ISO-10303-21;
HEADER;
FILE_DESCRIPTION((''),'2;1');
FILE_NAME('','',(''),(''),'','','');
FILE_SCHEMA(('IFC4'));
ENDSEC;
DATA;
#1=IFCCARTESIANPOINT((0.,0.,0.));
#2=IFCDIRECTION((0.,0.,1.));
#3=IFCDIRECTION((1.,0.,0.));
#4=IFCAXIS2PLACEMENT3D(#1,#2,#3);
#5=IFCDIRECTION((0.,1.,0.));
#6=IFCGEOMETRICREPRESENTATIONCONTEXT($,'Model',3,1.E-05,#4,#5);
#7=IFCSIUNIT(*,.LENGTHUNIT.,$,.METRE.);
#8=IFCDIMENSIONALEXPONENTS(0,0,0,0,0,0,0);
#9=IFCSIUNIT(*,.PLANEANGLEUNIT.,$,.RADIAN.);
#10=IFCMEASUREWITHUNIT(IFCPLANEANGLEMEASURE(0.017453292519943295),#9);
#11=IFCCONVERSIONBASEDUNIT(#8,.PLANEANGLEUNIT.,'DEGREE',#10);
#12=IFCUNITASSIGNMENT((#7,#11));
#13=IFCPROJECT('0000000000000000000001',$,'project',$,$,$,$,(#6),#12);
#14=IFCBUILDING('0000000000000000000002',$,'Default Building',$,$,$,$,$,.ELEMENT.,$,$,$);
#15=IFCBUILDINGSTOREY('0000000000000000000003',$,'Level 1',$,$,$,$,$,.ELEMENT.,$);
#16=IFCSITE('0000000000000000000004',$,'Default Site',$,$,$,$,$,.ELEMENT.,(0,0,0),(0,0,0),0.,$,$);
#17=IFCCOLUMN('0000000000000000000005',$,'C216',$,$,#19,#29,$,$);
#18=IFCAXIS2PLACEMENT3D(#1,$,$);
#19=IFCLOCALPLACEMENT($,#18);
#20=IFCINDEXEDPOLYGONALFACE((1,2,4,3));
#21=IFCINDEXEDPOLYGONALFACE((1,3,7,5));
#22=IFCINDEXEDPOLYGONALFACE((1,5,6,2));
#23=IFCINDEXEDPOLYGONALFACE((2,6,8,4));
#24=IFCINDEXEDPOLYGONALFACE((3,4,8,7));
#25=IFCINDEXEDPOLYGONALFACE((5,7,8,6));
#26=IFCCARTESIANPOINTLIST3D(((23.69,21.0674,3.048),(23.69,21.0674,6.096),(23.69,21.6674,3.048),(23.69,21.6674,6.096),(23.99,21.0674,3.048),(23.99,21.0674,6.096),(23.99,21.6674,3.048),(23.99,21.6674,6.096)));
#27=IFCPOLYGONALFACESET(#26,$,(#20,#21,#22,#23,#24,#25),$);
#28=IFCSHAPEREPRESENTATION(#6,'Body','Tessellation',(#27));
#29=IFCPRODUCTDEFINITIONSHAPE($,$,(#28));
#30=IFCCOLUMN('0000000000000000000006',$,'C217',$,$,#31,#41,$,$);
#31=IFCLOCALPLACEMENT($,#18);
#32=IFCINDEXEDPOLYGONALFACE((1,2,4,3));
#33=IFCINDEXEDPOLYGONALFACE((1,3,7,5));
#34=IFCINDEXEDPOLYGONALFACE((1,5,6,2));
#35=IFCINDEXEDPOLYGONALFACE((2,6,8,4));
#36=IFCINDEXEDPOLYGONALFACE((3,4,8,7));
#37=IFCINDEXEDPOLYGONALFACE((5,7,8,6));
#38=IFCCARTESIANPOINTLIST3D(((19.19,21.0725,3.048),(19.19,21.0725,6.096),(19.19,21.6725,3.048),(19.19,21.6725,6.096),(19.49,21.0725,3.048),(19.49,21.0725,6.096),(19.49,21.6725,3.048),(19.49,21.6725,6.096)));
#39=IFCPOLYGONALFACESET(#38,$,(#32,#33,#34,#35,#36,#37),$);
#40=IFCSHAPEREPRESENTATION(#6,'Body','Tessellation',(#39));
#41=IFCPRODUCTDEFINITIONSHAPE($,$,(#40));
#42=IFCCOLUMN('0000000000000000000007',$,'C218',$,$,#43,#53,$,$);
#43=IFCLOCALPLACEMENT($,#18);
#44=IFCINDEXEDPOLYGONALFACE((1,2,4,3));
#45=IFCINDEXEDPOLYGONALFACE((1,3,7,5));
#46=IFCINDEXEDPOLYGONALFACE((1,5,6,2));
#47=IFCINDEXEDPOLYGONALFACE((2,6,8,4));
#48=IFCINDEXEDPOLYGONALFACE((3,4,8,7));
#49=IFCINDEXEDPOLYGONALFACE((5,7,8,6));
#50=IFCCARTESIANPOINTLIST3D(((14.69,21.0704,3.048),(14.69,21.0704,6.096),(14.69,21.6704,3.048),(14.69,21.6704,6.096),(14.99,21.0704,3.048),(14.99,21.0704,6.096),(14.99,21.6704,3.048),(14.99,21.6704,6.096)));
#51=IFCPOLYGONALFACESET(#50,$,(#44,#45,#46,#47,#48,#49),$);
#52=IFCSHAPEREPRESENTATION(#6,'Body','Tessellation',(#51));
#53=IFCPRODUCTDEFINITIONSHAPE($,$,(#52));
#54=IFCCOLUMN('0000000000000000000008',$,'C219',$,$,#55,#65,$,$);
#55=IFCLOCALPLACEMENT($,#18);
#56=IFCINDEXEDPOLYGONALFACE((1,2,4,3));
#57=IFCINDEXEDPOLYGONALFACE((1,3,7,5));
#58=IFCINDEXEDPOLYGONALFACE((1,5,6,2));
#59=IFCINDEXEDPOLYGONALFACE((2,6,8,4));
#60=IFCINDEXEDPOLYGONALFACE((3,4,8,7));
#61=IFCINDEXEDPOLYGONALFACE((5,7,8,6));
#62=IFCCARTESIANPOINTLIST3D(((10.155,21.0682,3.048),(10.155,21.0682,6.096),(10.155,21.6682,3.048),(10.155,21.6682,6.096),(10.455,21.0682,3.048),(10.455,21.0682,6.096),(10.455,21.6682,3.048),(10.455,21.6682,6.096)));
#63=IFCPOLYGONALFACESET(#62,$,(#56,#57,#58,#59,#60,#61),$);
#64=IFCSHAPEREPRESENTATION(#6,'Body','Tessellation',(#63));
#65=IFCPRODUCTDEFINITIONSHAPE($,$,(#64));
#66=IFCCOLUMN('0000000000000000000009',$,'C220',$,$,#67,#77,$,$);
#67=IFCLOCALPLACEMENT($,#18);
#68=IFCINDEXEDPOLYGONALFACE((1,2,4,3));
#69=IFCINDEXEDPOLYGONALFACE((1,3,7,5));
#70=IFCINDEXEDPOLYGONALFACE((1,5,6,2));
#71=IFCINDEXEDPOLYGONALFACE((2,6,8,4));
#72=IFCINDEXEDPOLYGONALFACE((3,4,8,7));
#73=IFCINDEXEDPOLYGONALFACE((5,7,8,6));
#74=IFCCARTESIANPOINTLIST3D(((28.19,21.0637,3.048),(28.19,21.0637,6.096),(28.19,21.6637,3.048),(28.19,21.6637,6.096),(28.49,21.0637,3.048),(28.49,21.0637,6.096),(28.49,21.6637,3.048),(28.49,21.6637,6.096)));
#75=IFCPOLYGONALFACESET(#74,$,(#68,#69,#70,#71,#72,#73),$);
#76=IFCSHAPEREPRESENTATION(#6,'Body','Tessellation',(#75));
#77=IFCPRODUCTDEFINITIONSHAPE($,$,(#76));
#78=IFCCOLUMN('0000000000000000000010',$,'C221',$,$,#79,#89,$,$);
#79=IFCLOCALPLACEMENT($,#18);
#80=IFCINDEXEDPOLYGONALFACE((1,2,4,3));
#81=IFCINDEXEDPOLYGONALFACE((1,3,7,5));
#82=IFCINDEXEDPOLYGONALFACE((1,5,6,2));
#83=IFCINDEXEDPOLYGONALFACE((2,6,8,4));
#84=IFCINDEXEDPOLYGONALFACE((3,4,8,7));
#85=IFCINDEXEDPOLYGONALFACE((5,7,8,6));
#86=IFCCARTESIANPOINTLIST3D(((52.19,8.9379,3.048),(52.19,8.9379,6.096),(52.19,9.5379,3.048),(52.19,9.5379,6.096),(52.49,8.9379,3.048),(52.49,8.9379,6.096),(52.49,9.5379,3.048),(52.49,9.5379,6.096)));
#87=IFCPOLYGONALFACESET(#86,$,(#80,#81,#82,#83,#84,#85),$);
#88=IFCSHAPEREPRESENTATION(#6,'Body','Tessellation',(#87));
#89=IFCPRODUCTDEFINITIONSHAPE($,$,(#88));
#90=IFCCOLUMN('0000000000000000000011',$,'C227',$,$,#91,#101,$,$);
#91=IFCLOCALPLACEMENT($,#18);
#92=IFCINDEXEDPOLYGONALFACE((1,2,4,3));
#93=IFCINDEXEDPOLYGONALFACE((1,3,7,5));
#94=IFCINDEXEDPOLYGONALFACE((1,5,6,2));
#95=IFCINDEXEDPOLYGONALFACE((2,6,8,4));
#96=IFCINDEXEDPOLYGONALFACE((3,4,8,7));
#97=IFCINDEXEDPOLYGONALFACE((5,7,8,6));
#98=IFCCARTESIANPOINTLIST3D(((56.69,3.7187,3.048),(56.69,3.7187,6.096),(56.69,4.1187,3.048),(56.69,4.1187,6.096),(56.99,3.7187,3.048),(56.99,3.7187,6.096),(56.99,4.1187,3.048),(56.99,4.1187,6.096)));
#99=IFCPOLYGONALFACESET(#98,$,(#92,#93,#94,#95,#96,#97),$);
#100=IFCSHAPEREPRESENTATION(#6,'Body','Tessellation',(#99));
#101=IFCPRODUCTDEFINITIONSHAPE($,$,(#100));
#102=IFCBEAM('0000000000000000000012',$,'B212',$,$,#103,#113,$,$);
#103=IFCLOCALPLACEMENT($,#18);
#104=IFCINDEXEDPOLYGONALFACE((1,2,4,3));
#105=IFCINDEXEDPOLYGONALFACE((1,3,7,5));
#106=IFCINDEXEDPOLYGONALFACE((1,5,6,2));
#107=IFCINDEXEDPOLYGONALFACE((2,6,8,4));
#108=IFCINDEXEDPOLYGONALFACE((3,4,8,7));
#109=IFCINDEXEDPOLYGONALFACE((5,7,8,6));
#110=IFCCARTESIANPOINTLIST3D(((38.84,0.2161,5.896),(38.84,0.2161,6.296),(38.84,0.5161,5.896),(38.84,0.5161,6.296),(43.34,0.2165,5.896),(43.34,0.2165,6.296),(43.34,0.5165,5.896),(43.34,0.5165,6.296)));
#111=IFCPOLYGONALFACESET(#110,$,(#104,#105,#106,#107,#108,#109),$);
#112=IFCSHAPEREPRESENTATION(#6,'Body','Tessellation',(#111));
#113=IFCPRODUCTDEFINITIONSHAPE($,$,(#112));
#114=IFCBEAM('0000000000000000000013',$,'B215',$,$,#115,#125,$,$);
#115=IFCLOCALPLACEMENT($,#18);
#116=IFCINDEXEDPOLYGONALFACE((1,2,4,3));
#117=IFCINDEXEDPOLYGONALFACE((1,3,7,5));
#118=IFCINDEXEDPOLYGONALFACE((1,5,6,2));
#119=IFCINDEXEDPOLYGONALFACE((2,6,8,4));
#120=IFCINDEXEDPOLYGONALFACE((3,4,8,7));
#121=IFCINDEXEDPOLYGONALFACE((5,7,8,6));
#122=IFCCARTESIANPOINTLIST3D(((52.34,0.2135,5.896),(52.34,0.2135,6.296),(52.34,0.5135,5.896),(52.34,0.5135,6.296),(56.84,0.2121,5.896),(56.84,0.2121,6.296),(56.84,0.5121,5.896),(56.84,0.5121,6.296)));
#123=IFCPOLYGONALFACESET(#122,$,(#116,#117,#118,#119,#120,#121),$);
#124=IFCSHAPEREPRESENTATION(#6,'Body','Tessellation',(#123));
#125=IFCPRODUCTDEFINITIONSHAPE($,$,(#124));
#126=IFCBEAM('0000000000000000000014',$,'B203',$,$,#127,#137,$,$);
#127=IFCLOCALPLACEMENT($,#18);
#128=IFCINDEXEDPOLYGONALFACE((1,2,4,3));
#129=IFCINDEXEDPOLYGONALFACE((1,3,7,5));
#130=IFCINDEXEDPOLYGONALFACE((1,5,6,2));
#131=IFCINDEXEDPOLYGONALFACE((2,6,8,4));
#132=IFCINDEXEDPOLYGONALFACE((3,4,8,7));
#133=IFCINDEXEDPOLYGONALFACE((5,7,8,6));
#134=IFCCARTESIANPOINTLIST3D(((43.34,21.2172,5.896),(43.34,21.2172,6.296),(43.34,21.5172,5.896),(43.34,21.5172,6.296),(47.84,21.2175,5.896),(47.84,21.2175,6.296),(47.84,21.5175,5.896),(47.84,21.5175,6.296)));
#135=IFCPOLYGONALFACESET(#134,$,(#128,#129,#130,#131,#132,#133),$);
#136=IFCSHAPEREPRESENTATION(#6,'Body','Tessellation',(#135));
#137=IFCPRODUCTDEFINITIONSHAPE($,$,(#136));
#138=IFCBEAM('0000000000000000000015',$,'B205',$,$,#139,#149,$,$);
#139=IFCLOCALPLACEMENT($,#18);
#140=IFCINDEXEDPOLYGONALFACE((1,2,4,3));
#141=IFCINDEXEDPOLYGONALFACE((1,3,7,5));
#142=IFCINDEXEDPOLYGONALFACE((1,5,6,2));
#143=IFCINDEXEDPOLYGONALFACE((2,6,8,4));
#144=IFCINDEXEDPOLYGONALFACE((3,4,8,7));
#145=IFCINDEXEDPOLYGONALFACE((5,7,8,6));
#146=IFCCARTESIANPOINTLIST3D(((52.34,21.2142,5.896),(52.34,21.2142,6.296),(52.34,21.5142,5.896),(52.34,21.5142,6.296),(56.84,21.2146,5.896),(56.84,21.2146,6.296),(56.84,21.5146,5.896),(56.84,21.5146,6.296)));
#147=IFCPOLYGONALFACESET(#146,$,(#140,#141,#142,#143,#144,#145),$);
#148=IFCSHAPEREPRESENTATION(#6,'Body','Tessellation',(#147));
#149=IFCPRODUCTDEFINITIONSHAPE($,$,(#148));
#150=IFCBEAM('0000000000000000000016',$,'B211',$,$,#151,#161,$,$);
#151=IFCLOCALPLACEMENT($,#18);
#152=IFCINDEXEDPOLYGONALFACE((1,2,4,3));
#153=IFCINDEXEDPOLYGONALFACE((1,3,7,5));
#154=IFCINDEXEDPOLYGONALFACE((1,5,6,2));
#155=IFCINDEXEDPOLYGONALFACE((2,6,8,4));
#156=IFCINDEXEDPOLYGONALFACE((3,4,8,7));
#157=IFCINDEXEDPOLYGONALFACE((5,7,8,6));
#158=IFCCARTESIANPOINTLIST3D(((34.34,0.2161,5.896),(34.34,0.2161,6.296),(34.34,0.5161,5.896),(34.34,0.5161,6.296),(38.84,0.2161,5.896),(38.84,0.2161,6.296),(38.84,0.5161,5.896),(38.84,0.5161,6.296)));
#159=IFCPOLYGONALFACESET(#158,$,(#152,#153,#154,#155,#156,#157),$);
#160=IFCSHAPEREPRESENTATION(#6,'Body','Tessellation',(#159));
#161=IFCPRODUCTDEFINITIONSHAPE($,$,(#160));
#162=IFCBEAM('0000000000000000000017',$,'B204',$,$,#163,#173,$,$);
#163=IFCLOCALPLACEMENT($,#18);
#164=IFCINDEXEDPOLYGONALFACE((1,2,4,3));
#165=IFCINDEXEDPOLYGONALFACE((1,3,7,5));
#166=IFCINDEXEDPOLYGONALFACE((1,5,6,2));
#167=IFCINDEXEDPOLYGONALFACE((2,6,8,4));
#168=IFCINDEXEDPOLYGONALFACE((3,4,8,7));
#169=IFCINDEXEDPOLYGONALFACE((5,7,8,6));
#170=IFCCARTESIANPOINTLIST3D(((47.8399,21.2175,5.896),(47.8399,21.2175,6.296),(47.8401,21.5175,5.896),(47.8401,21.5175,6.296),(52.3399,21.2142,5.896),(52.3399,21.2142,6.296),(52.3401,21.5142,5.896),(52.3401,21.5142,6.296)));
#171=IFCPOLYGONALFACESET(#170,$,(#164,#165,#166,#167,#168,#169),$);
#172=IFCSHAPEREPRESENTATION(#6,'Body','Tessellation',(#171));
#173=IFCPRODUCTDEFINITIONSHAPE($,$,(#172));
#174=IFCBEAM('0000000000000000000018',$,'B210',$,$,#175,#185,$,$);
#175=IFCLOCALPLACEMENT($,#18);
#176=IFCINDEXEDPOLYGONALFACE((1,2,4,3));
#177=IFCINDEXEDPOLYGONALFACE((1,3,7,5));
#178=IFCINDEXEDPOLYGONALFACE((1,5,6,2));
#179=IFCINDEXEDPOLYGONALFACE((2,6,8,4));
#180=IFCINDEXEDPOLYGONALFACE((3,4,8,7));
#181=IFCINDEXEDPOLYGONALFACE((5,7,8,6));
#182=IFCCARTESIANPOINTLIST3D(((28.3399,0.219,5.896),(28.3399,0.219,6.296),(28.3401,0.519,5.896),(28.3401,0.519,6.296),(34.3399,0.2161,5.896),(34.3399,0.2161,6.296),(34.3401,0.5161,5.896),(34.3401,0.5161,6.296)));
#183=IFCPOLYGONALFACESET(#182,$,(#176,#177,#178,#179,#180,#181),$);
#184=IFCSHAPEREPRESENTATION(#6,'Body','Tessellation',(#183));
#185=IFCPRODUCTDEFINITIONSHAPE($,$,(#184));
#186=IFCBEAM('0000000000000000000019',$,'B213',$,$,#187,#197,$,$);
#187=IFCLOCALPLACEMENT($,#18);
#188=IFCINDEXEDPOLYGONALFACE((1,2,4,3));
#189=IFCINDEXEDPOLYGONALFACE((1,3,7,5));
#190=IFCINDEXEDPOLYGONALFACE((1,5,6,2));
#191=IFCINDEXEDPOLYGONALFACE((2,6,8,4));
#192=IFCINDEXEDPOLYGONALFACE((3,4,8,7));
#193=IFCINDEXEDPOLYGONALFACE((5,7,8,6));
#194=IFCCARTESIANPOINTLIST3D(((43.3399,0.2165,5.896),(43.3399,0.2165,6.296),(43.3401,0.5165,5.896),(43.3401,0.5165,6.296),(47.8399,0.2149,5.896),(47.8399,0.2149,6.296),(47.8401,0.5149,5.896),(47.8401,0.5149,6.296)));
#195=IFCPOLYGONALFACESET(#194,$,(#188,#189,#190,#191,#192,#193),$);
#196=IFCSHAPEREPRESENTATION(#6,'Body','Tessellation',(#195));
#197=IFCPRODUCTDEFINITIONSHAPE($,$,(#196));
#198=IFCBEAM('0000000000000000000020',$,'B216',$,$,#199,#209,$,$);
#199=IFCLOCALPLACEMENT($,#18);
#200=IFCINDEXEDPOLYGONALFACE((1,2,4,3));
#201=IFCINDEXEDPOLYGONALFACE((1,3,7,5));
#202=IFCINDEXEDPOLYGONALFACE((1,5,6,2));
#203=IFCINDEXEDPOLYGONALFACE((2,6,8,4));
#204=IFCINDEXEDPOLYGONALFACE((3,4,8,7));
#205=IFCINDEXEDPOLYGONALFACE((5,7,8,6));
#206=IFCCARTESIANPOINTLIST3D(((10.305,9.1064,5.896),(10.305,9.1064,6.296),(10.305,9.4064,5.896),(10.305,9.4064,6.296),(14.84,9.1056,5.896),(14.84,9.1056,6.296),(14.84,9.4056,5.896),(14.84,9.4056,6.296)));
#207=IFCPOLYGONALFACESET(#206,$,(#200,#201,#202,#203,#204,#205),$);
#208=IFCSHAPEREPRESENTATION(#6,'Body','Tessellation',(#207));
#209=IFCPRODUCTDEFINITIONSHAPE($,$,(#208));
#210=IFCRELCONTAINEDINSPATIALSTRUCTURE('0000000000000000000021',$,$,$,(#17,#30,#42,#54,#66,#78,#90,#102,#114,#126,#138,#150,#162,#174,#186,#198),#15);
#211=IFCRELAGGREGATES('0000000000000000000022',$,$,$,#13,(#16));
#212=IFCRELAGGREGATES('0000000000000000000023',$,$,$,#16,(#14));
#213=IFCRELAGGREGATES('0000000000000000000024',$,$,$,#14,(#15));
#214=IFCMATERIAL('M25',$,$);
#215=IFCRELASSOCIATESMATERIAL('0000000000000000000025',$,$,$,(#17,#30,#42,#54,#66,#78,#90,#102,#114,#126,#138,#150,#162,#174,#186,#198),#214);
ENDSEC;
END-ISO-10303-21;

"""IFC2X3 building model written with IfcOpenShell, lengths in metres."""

from ifc_helpers import new_model, entity, si_unit, converted_unit, direction, frame, frame_2d, origin_with_axes, place, context, project, spatial, rectangle, extrude, material, element, save


model = new_model("IFC2X3")

# Units and contexts
model_context = context("Model", 3, precision=1e-05, world=origin_with_axes(), true_north=direction((0.0, 1.0, 0.0)))
ifc_project = project(units=[si_unit("LENGTHUNIT", "METRE"), converted_unit("PLANEANGLEUNIT", "DEGREE", entity("IfcPlaneAngleMeasure", 0.017453292519943295), si_unit("PLANEANGLEUNIT", "RADIAN"), dimensions=[0, 0, 0, 0, 0, 0, 0])], contexts=[model_context])

# Site, building, storey
site = spatial("IfcSite", under=ifc_project, Name="Default Site", CompositionType="ELEMENT", RefLatitude=(0, 0, 0), RefLongitude=(0, 0, 0), RefElevation=0.0)
building = spatial("IfcBuilding", under=site, Name="Default Building", CompositionType="ELEMENT")
storey = spatial("IfcBuildingStorey", under=building, Name="Level 1", CompositionType="ELEMENT")

# Columns
ifc_material = material(Name="M25")
placement = place(None, origin_with_axes())
element("IfcColumn", 1, at=placement, inside=storey, material=ifc_material, Name="C216", context=model_context, shape_type="SweptSolid", body=[
    extrude(rectangle(XDim=0.3, YDim=0.6, at=frame_2d((0.0, 0.0), x_axis=(1.0, 0.0, 0.0))), frame((23.84, 21.3674, 3.048), z_axis=(0.0, 0.0, 1.0), x_axis=(1.0, 0.0, 0.0)), (0.0, 0.0, 1.0), 3.048),
])
element("IfcColumn", 2, at=placement, inside=storey, material=ifc_material, Name="C217", context=model_context, shape_type="SweptSolid", body=[
    extrude(rectangle(XDim=0.3, YDim=0.6, at=frame_2d((0.0, 0.0), x_axis=(1.0, 0.0, 0.0))), frame((19.34, 21.3725, 3.048), z_axis=(0.0, 0.0, 1.0), x_axis=(1.0, 0.0, 0.0)), (0.0, 0.0, 1.0), 3.048),
])
element("IfcColumn", 3, at=placement, inside=storey, material=ifc_material, Name="C218", context=model_context, shape_type="SweptSolid", body=[
    extrude(rectangle(XDim=0.3, YDim=0.6, at=frame_2d((0.0, 0.0), x_axis=(1.0, 0.0, 0.0))), frame((14.84, 21.3704, 3.048), z_axis=(0.0, 0.0, 1.0), x_axis=(1.0, 0.0, 0.0)), (0.0, 0.0, 1.0), 3.048),
])
element("IfcColumn", 4, at=placement, inside=storey, material=ifc_material, Name="C219", context=model_context, shape_type="SweptSolid", body=[
    extrude(rectangle(XDim=0.3, YDim=0.6, at=frame_2d((0.0, 0.0), x_axis=(1.0, 0.0, 0.0))), frame((10.305, 21.3682, 3.048), z_axis=(0.0, 0.0, 1.0), x_axis=(1.0, 0.0, 0.0)), (0.0, 0.0, 1.0), 3.048),
])
element("IfcColumn", 5, at=placement, inside=storey, material=ifc_material, Name="C220", context=model_context, shape_type="SweptSolid", body=[
    extrude(rectangle(XDim=0.3, YDim=0.6, at=frame_2d((0.0, 0.0), x_axis=(1.0, 0.0, 0.0))), frame((28.34, 21.3637, 3.048), z_axis=(0.0, 0.0, 1.0), x_axis=(1.0, 0.0, 0.0)), (0.0, 0.0, 1.0), 3.048),
])
element("IfcColumn", 6, at=placement, inside=storey, material=ifc_material, Name="C221", context=model_context, shape_type="SweptSolid", body=[
    extrude(rectangle(XDim=0.3, YDim=0.6, at=frame_2d((0.0, 0.0), x_axis=(1.0, 0.0, 0.0))), frame((52.34, 9.2379, 3.048), z_axis=(0.0, 0.0, 1.0), x_axis=(1.0, 0.0, 0.0)), (0.0, 0.0, 1.0), 3.048),
])
element("IfcColumn", 7, at=placement, inside=storey, material=ifc_material, Name="C227", context=model_context, shape_type="SweptSolid", body=[
    extrude(rectangle(XDim=0.3, YDim=0.4, at=frame_2d((0.0, 0.0), x_axis=(1.0, 0.0, 0.0))), frame((56.84, 3.9187, 3.048), z_axis=(0.0, 0.0, 1.0), x_axis=(1.0, 0.0, 0.0)), (0.0, 0.0, 1.0), 3.048),
])

# Beams
element("IfcBeam", 8, at=placement, inside=storey, material=ifc_material, Name="B212", context=model_context, shape_type="SweptSolid", body=[
    extrude(rectangle(XDim=0.3, YDim=0.4, at=frame_2d((0.0, 0.0), x_axis=(0.0, 1.0, 0.0))), frame((38.84, 0.3661, 6.096), z_axis=(1.0, 0.000077, 0.0), x_axis=(0.0, 0.0, -1.0)), (0.0, 0.0, 1.0), 4.5),
])
element("IfcBeam", 9, at=placement, inside=storey, material=ifc_material, Name="B215", context=model_context, shape_type="SweptSolid", body=[
    extrude(rectangle(XDim=0.3, YDim=0.4, at=frame_2d((0.0, 0.0), x_axis=(0.0, 1.0, 0.0))), frame((52.34, 0.3635, 6.096), z_axis=(1.0, -0.000311, 0.0), x_axis=(0.0, 0.0, -1.0)), (0.0, 0.0, 1.0), 4.5),
])
element("IfcBeam", 10, at=placement, inside=storey, material=ifc_material, Name="B203", context=model_context, shape_type="SweptSolid", body=[
    extrude(rectangle(XDim=0.3, YDim=0.4, at=frame_2d((0.0, 0.0), x_axis=(0.0, 1.0, 0.0))), frame((43.34, 21.3672, 6.096), z_axis=(1.0, 0.000075, 0.0), x_axis=(0.0, 0.0, -1.0)), (0.0, 0.0, 1.0), 4.5),
])
element("IfcBeam", 11, at=placement, inside=storey, material=ifc_material, Name="B205", context=model_context, shape_type="SweptSolid", body=[
    extrude(rectangle(XDim=0.3, YDim=0.4, at=frame_2d((0.0, 0.0), x_axis=(0.0, 1.0, 0.0))), frame((52.34, 21.3642, 6.096), z_axis=(1.0, 0.000102, 0.0), x_axis=(0.0, 0.0, -1.0)), (0.0, 0.0, 1.0), 4.5),
])
element("IfcBeam", 12, at=placement, inside=storey, material=ifc_material, Name="B211", context=model_context, shape_type="SweptSolid", body=[
    extrude(rectangle(XDim=0.3, YDim=0.4, at=frame_2d((0.0, 0.0), x_axis=(0.0, 1.0, 0.0))), frame((34.34, 0.3661, 6.096), z_axis=(1.0, 0.000003, 0.0), x_axis=(0.0, 0.0, -1.0)), (0.0, 0.0, 1.0), 4.5),
])
element("IfcBeam", 13, at=placement, inside=storey, material=ifc_material, Name="B204", context=model_context, shape_type="SweptSolid", body=[
    extrude(rectangle(XDim=0.3, YDim=0.4, at=frame_2d((0.0, 0.0), x_axis=(0.0, 1.0, 0.0))), frame((47.84, 21.3675, 6.096), z_axis=(1.0, -0.000744, 0.0), x_axis=(0.0, 0.0, -1.0)), (0.0, 0.0, 1.0), 4.5),
])
element("IfcBeam", 14, at=placement, inside=storey, material=ifc_material, Name="B210", context=model_context, shape_type="SweptSolid", body=[
    extrude(rectangle(XDim=0.3, YDim=0.4, at=frame_2d((0.0, 0.0), x_axis=(0.0, 1.0, 0.0))), frame((28.34, 0.369, 6.096), z_axis=(1.0, -0.000487, 0.0), x_axis=(0.0, 0.0, -1.0)), (0.0, 0.0, 1.0), 6.0),
])
element("IfcBeam", 15, at=placement, inside=storey, material=ifc_material, Name="B213", context=model_context, shape_type="SweptSolid", body=[
    extrude(rectangle(XDim=0.3, YDim=0.4, at=frame_2d((0.0, 0.0), x_axis=(0.0, 1.0, 0.0))), frame((43.34, 0.3665, 6.096), z_axis=(1.0, -0.000358, 0.0), x_axis=(0.0, 0.0, -1.0)), (0.0, 0.0, 1.0), 4.5),
])
element("IfcBeam", 16, at=placement, inside=storey, material=ifc_material, Name="B216", context=model_context, shape_type="SweptSolid", body=[
    extrude(rectangle(XDim=0.3, YDim=0.4, at=frame_2d((0.0, 0.0), x_axis=(0.0, 1.0, 0.0))), frame((10.305, 9.2564, 6.096), z_axis=(1.0, -0.000182, 0.0), x_axis=(0.0, 0.0, -1.0)), (0.0, 0.0, 1.0), 4.535),
])

save(model, "model.ifc")
